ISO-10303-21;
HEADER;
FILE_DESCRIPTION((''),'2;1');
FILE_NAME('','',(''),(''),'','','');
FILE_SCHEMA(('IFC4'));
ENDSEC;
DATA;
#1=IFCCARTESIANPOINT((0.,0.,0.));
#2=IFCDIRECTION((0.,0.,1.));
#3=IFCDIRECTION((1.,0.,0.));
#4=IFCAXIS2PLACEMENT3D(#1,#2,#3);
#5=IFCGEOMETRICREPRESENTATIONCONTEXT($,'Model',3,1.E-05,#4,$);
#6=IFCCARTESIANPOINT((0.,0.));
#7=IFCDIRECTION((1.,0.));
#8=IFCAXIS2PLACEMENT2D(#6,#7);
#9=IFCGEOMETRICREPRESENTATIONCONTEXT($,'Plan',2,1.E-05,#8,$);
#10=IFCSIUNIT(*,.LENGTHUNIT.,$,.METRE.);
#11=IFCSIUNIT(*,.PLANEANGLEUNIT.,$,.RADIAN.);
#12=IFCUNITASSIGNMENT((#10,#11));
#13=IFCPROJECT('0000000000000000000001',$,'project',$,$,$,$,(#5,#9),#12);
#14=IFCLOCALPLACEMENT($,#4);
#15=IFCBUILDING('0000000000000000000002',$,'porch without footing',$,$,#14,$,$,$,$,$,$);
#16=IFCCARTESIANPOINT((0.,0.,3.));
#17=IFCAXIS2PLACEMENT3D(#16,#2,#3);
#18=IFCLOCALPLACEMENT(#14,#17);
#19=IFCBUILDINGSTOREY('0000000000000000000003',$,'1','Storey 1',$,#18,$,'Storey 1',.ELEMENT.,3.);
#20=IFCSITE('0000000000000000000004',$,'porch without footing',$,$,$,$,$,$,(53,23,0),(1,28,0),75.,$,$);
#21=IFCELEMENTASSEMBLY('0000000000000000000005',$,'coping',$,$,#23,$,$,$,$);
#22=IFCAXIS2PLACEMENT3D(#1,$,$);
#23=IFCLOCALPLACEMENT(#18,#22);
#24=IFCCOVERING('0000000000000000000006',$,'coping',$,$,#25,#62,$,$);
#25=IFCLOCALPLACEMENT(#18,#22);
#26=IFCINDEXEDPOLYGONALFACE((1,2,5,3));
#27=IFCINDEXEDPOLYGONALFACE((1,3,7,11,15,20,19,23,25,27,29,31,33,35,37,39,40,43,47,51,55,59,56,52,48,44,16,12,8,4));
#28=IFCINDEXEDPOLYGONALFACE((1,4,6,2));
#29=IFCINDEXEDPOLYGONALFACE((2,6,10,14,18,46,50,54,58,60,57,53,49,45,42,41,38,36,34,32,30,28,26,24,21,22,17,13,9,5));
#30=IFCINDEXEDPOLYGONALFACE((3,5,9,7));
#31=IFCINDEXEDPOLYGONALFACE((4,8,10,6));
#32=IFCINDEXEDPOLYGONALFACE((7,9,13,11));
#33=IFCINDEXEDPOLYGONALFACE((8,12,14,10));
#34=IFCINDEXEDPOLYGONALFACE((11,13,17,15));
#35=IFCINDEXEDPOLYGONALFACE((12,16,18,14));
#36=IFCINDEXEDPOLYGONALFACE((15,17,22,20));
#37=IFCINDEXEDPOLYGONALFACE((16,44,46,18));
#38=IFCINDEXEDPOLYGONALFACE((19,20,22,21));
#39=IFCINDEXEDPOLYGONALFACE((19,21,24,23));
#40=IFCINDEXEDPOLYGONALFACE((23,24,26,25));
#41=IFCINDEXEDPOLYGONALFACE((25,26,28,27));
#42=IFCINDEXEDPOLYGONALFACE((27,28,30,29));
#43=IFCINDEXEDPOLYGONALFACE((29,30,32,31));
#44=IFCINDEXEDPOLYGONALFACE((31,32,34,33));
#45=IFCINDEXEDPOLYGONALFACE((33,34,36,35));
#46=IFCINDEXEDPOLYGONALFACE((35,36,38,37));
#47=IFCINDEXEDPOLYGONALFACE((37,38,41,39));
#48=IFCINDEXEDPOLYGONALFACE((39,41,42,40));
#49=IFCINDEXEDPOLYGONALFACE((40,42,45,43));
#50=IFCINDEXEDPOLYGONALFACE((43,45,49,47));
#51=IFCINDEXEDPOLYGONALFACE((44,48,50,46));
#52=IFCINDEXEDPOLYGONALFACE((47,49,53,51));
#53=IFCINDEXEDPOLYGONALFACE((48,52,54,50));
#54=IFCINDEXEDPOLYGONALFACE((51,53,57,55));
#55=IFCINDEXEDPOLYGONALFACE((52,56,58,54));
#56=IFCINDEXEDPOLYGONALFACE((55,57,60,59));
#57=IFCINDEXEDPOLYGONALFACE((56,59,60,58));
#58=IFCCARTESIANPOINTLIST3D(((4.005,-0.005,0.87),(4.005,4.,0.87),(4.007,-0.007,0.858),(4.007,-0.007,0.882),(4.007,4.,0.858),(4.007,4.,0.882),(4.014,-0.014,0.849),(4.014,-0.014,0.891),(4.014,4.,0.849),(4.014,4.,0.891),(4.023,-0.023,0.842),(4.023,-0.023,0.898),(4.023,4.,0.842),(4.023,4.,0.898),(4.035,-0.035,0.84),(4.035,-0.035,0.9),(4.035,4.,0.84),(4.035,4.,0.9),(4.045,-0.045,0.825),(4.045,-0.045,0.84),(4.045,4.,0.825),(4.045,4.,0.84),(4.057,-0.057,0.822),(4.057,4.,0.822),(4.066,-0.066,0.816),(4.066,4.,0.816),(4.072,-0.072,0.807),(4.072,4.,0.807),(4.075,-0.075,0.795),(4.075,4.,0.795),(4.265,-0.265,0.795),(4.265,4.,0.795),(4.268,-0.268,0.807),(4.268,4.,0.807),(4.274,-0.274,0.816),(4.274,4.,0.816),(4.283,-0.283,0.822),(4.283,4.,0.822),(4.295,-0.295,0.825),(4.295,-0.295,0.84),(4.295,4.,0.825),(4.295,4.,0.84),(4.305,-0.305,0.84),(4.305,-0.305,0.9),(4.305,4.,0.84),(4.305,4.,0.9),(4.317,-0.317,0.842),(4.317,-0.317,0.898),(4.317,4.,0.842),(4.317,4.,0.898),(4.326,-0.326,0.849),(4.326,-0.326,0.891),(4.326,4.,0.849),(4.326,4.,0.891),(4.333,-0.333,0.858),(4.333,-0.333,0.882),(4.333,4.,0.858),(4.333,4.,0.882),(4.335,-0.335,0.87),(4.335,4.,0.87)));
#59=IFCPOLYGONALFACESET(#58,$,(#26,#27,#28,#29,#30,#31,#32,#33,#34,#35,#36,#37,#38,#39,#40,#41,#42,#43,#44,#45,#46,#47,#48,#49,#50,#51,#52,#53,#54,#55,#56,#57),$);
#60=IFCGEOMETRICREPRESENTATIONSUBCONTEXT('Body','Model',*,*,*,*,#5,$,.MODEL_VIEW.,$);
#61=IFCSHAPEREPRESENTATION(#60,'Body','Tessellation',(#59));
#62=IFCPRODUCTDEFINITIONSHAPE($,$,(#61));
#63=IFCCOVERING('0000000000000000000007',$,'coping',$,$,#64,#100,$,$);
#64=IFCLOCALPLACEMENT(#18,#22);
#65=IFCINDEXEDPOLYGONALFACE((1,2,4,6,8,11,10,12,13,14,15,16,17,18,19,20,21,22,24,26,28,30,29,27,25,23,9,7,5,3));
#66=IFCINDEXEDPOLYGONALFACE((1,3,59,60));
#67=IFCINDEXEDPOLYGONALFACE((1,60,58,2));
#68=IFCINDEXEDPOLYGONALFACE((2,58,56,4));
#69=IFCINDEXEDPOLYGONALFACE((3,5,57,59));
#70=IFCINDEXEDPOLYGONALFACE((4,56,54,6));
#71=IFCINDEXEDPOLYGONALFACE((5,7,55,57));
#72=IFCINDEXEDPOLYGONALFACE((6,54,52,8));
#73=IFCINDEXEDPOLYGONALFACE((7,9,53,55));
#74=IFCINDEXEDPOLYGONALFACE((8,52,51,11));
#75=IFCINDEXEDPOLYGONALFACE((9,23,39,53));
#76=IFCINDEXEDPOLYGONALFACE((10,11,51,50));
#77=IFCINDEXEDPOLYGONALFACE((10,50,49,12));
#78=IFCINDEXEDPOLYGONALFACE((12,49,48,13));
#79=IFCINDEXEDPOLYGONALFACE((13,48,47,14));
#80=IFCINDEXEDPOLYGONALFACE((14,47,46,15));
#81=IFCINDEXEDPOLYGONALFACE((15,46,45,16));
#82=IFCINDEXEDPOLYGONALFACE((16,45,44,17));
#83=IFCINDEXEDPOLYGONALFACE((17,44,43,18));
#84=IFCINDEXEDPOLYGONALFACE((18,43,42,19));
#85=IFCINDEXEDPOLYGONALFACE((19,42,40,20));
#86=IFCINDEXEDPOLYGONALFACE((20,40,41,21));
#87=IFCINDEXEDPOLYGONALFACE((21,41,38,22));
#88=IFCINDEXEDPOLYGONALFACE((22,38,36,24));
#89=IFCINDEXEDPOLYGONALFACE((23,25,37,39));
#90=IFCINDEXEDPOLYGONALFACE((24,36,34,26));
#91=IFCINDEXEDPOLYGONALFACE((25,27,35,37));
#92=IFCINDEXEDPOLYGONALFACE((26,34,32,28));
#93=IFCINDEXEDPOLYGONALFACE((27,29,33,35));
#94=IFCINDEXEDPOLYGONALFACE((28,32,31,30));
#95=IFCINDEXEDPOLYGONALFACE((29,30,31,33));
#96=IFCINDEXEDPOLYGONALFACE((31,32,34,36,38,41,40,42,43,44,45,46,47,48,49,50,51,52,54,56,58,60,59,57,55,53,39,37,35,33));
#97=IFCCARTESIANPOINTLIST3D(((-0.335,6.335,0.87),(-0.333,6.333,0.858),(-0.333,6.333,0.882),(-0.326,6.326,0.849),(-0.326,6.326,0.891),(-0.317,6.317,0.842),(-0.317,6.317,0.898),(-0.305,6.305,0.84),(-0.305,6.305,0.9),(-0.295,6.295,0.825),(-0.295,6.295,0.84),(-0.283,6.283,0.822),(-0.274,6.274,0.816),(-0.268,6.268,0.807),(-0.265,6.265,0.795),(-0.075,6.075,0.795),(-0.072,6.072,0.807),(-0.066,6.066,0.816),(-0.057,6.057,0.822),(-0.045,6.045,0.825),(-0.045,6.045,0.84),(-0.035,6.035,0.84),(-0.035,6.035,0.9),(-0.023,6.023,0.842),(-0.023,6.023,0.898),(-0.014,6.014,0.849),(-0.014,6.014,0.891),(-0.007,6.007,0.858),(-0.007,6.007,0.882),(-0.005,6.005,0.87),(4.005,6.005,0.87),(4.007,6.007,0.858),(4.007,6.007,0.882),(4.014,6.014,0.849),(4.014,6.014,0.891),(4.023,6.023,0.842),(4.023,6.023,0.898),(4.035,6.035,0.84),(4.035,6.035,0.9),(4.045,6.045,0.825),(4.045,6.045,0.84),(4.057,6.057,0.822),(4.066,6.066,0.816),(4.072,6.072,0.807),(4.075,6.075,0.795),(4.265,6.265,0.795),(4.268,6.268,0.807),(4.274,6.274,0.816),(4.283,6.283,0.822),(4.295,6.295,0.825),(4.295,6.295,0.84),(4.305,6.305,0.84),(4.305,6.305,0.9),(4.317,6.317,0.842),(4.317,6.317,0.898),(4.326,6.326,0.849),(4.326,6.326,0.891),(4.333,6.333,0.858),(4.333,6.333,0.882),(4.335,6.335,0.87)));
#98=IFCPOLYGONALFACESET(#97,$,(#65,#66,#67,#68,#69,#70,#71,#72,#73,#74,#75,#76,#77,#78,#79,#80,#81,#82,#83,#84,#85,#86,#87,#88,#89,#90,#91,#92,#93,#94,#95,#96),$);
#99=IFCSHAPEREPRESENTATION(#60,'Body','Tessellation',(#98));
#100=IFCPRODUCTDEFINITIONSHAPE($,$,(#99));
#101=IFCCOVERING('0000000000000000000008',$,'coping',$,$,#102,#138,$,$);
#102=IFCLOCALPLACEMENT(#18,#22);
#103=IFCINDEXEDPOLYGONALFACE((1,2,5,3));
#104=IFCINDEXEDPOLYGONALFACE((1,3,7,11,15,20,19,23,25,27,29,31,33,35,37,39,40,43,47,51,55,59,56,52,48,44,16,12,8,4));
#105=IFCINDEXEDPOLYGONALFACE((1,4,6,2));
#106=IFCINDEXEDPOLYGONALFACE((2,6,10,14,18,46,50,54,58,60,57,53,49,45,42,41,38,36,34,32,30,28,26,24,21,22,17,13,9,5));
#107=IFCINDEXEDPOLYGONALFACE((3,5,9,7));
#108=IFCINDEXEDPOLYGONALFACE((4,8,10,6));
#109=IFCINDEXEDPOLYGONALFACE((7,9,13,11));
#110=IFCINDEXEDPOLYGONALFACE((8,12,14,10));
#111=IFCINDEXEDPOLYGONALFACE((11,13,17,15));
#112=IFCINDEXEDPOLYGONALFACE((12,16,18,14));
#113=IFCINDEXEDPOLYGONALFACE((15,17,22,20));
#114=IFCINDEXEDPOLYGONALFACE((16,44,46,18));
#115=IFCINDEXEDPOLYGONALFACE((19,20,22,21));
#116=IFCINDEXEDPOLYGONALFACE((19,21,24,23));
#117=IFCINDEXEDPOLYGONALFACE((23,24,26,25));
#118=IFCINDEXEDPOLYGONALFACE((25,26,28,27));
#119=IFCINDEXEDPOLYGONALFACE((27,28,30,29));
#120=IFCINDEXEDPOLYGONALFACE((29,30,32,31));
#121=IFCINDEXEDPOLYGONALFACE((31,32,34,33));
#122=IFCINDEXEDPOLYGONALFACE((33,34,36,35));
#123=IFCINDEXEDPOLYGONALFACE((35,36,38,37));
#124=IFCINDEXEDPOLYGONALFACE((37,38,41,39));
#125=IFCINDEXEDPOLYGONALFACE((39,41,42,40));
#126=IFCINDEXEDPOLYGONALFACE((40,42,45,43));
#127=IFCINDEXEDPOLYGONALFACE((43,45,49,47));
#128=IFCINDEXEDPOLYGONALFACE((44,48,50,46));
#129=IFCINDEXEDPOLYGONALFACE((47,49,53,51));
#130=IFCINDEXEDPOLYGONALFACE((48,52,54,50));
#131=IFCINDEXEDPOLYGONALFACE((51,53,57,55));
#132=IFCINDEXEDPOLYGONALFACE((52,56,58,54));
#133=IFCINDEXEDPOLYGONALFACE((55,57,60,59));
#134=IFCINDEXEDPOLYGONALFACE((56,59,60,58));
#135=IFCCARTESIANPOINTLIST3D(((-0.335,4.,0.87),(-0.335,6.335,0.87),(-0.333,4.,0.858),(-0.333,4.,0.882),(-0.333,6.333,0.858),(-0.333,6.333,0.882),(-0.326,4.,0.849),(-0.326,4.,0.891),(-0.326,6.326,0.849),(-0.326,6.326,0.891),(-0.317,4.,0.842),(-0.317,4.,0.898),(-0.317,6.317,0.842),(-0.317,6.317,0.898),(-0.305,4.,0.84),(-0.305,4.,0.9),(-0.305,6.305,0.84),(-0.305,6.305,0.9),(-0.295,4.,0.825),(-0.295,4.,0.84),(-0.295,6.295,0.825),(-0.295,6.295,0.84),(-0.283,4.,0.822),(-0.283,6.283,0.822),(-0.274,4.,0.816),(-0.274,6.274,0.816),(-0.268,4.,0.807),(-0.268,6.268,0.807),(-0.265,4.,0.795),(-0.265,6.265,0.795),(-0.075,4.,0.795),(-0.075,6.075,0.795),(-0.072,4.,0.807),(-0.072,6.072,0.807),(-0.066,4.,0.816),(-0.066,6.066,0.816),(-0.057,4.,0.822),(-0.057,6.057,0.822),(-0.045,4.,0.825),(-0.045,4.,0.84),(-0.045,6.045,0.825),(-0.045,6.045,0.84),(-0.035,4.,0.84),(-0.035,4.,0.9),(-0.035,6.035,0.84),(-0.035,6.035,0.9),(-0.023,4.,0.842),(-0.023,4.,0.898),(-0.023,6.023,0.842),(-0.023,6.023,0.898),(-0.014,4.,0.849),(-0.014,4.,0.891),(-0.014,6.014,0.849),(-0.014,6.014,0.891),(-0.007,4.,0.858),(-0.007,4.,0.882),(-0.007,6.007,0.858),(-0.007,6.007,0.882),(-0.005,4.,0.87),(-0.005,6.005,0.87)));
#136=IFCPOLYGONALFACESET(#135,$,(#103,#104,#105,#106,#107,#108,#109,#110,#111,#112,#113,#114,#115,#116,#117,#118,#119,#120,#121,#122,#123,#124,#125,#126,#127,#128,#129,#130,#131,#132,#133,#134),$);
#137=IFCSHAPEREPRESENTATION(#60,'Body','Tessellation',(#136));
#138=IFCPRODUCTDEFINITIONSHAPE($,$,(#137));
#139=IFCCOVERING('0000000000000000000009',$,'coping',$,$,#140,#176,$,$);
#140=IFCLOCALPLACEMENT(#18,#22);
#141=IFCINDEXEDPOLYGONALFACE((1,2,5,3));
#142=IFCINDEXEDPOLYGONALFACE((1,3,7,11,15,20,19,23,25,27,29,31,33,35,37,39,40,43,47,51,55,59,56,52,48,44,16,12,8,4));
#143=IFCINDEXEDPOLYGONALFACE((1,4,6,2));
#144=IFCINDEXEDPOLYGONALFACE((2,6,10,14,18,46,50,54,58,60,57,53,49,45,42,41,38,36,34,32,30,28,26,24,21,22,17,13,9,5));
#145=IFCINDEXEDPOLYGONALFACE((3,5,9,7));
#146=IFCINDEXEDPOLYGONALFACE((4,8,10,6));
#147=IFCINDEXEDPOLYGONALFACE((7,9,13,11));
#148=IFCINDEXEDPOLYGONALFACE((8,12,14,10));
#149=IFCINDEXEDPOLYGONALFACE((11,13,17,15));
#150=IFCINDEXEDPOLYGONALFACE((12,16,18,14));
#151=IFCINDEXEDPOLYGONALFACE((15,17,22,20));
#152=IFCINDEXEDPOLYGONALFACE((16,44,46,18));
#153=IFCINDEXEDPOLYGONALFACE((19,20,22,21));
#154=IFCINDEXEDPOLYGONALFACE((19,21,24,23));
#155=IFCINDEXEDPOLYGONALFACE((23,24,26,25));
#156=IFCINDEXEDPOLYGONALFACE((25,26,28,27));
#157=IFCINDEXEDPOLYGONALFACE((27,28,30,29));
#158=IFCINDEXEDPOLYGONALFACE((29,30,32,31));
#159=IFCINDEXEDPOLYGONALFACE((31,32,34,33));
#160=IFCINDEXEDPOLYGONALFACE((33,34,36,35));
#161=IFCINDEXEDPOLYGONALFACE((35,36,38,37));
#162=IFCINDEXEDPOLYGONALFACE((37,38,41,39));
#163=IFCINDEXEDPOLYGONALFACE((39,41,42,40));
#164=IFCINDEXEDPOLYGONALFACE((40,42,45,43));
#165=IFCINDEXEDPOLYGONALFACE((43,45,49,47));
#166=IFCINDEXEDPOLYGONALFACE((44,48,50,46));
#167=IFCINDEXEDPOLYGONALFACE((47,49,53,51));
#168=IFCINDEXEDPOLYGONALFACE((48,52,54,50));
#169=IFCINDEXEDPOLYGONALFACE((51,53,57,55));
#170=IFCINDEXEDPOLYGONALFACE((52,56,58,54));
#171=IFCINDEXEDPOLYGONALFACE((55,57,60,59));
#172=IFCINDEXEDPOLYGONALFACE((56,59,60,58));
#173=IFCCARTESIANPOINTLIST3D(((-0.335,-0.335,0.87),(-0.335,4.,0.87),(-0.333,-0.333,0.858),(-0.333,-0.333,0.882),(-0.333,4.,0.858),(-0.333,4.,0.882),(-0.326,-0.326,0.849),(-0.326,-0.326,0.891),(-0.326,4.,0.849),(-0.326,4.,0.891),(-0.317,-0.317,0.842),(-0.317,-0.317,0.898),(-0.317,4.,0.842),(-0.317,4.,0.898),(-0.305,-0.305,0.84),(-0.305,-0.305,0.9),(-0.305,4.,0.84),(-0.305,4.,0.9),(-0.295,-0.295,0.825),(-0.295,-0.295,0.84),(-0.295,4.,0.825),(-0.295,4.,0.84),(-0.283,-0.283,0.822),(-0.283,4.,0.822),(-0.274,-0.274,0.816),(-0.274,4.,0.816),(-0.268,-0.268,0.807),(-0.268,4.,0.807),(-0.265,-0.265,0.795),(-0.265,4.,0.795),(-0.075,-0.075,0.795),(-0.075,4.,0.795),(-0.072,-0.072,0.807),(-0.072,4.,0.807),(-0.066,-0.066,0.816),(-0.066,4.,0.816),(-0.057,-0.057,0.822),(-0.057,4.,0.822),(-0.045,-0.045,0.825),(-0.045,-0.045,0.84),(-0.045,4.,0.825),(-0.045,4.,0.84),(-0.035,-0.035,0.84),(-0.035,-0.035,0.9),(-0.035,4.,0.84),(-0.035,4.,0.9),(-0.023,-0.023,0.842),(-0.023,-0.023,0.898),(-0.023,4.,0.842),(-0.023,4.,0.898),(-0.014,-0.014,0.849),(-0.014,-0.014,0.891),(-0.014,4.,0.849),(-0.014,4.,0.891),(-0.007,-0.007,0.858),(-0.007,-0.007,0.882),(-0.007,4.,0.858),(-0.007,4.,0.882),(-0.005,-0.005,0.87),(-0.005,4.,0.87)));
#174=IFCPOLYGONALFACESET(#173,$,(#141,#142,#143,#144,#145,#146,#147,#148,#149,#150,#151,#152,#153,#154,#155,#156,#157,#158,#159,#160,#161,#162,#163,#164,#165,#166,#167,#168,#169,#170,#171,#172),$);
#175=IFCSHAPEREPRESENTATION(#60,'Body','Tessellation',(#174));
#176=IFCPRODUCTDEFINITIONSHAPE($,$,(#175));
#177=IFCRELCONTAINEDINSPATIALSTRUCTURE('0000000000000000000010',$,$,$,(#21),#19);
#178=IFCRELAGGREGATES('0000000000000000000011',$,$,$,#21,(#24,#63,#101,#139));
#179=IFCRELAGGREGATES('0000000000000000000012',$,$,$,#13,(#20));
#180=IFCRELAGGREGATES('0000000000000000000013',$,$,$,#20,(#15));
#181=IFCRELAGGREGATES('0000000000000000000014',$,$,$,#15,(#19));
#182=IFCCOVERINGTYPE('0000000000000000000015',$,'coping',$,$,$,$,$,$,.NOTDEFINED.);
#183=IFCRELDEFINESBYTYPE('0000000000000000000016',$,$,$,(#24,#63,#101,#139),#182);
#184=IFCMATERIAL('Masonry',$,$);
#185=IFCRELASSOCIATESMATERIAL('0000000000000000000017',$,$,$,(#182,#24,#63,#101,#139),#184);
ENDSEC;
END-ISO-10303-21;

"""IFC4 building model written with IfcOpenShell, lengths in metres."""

from ifc_helpers import new_model, si_unit, frame, origin_with_axes, origin_2d_with_axis, place, context, subcontext, project, spatial, polyline, outline, extrude, clip, halfspace, material, material_profile, profile_set, profile_usage, type_object, element, aggregate, save


model = new_model("IFC4")

# Units and contexts
model_context = context("Model", 3, precision=1e-05, world=origin_with_axes())
plan_context = context("Plan", 2, precision=1e-05, world=origin_2d_with_axis())
body_context = subcontext(model_context, "Body", "Model", "MODEL_VIEW")
ifc_project = project(units=[si_unit("LENGTHUNIT", "METRE"), si_unit("PLANEANGLEUNIT", "RADIAN")], contexts=[model_context, plan_context])

# Site, building, storey
site = spatial("IfcSite", under=ifc_project, Name="porch without footing", RefLatitude=(53, 23, 0), RefLongitude=(1, 28, 0), RefElevation=75.0)
building_placement = place(None, origin_with_axes())
building = spatial("IfcBuilding", under=site, at=building_placement, Name="porch without footing")
storey_placement = place(building_placement, frame((0.0, 0.0, 3.0), z_axis=(0.0, 0.0, 1.0), x_axis=(1.0, 0.0, 0.0)))
storey = spatial("IfcBuildingStorey", under=building, at=storey_placement, Name="1", Description="Storey 1", LongName="Storey 1", CompositionType="ELEMENT", Elevation=3.0)

# Shared definitions
ifc_material_1 = material(Name="Masonry")

# Element assembly, coverings
assembly_1_placement = place(storey_placement, frame((0.0, 0.0, -3.0), z_axis=(0.0, 0.0, 1.0), x_axis=(1.0, 0.0, 0.0)))
assembly_1 = element("IfcElementAssembly", 1, at=assembly_1_placement, inside=storey, Name="coping")
ifc_material_profile_1 = material_profile(ifc_material_1, outline(polyline([(0.265, 0.795), (0.268, 0.807), (0.274, 0.816), (0.283, 0.822), (0.295, 0.825), (0.295, 0.84), (0.305, 0.84), (0.317, 0.842), (0.326, 0.849), (0.333, 0.858), (0.335, 0.87), (0.333, 0.882), (0.326, 0.891), (0.317, 0.898), (0.305, 0.9), (0.035, 0.9), (0.023, 0.898), (0.014, 0.891), (0.007, 0.882), (0.005, 0.87), (0.007, 0.858), (0.014, 0.849), (0.023, 0.842), (0.035, 0.84), (0.045, 0.84), (0.045, 0.825), (0.057, 0.822), (0.066, 0.816), (0.072, 0.807), (0.075, 0.795), (0.265, 0.795)])))
ifc_profile_set_1 = profile_set([ifc_material_profile_1])
covering_type_1 = type_object("IfcCoveringType", Name="coping", PredefinedType="NOTDEFINED", material=ifc_profile_set_1)
ifc_profile_usage_1 = profile_usage(ifc_profile_set_1)
covering_1_placement = place(assembly_1_placement, frame((4.0, 5.0, 3.0), z_axis=(0.0, -1.0, 0.0), x_axis=(1.0, 0.0, 0.0)))
covering_1 = element("IfcCovering", 2, at=covering_1_placement, type_object=covering_type_1, material=ifc_profile_usage_1, Name="coping", context=body_context, shape_type="Clipping", body=[
    clip(clip(extrude(outline(polyline([(0.265, 0.795), (0.268, 0.807), (0.274, 0.816), (0.283, 0.822), (0.295, 0.825), (0.295, 0.84), (0.305, 0.84), (0.317, 0.842), (0.326, 0.849), (0.333, 0.858), (0.335, 0.87), (0.333, 0.882), (0.326, 0.891), (0.317, 0.898), (0.305, 0.9), (0.035, 0.9), (0.023, 0.898), (0.014, 0.891), (0.007, 0.882), (0.005, 0.87), (0.007, 0.858), (0.014, 0.849), (0.023, 0.842), (0.035, 0.84), (0.045, 0.84), (0.045, 0.825), (0.057, 0.822), (0.066, 0.816), (0.072, 0.807), (0.075, 0.795), (0.265, 0.795)])), origin_with_axes(), (0.0, 0.0, 1.0), 6.0), halfspace(frame((0.0, -3.0, 1.0), z_axis=(0.0, 0.0, -1.0), x_axis=(1.0, 0.0, 0.0)), False)), halfspace(frame((0.0, -3.0, 5.0), z_axis=(-0.707107, 0.0, 0.707107), x_axis=(0.0, 1.0, 0.0)), False)),
])
ifc_profile_usage_2 = profile_usage(ifc_profile_set_1)
covering_2_placement = place(assembly_1_placement, frame((-1.0, 6.0, 3.0), z_axis=(1.0, 0.0, 0.0), x_axis=(0.0, 1.0, 0.0)))
covering_2 = element("IfcCovering", 3, at=covering_2_placement, type_object=covering_type_1, material=ifc_profile_usage_2, Name="coping", context=body_context, shape_type="Clipping", body=[
    clip(clip(extrude(outline(polyline([(0.265, 0.795), (0.268, 0.807), (0.274, 0.816), (0.283, 0.822), (0.295, 0.825), (0.295, 0.84), (0.305, 0.84), (0.317, 0.842), (0.326, 0.849), (0.333, 0.858), (0.335, 0.87), (0.333, 0.882), (0.326, 0.891), (0.317, 0.898), (0.305, 0.9), (0.035, 0.9), (0.023, 0.898), (0.014, 0.891), (0.007, 0.882), (0.005, 0.87), (0.007, 0.858), (0.014, 0.849), (0.023, 0.842), (0.035, 0.84), (0.045, 0.84), (0.045, 0.825), (0.057, 0.822), (0.066, 0.816), (0.072, 0.807), (0.075, 0.795), (0.265, 0.795)])), origin_with_axes(), (0.0, 0.0, 1.0), 6.0), halfspace(frame((0.0, -3.0, 1.0), z_axis=(-0.707107, 0.0, -0.707107), x_axis=(0.0, 1.0, 0.0)), False)), halfspace(frame((0.0, -3.0, 5.0), z_axis=(-0.707107, 0.0, 0.707107), x_axis=(0.0, 1.0, 0.0)), False)),
])
ifc_profile_usage_3 = profile_usage(ifc_profile_set_1)
covering_3_placement = place(assembly_1_placement, frame((0.0, 3.0, 3.0), z_axis=(0.0, 1.0, 0.0), x_axis=(-1.0, 0.0, 0.0)))
covering_3 = element("IfcCovering", 4, at=covering_3_placement, type_object=covering_type_1, material=ifc_profile_usage_3, Name="coping", context=body_context, shape_type="Clipping", body=[
    clip(clip(extrude(outline(polyline([(0.265, 0.795), (0.268, 0.807), (0.274, 0.816), (0.283, 0.822), (0.295, 0.825), (0.295, 0.84), (0.305, 0.84), (0.317, 0.842), (0.326, 0.849), (0.333, 0.858), (0.335, 0.87), (0.333, 0.882), (0.326, 0.891), (0.317, 0.898), (0.305, 0.9), (0.035, 0.9), (0.023, 0.898), (0.014, 0.891), (0.007, 0.882), (0.005, 0.87), (0.007, 0.858), (0.014, 0.849), (0.023, 0.842), (0.035, 0.84), (0.045, 0.84), (0.045, 0.825), (0.057, 0.822), (0.066, 0.816), (0.072, 0.807), (0.075, 0.795), (0.265, 0.795)])), origin_with_axes(), (0.0, 0.0, 1.0), 4.0), halfspace(frame((0.0, -3.0, 1.0), z_axis=(0.0, 0.0, -1.0), x_axis=(1.0, 0.0, 0.0)), False)), halfspace(frame((0.0, -3.0, 3.0), z_axis=(-0.707107, 0.0, 0.707107), x_axis=(0.0, 1.0, 0.0)), False)),
])
ifc_profile_usage_4 = profile_usage(ifc_profile_set_1)
covering_4_placement = place(assembly_1_placement, frame((0.0, -1.0, 3.0), z_axis=(0.0, 1.0, 0.0), x_axis=(-1.0, 0.0, 0.0)))
covering_4 = element("IfcCovering", 5, at=covering_4_placement, type_object=covering_type_1, material=ifc_profile_usage_4, Name="coping", context=body_context, shape_type="Clipping", body=[
    clip(clip(extrude(outline(polyline([(0.265, 0.795), (0.268, 0.807), (0.274, 0.816), (0.283, 0.822), (0.295, 0.825), (0.295, 0.84), (0.305, 0.84), (0.317, 0.842), (0.326, 0.849), (0.333, 0.858), (0.335, 0.87), (0.333, 0.882), (0.326, 0.891), (0.317, 0.898), (0.305, 0.9), (0.035, 0.9), (0.023, 0.898), (0.014, 0.891), (0.007, 0.882), (0.005, 0.87), (0.007, 0.858), (0.014, 0.849), (0.023, 0.842), (0.035, 0.84), (0.045, 0.84), (0.045, 0.825), (0.057, 0.822), (0.066, 0.816), (0.072, 0.807), (0.075, 0.795), (0.265, 0.795)])), origin_with_axes(), (0.0, 0.0, 1.0), 6.0), halfspace(frame((0.0, -3.0, 1.0), z_axis=(-0.707107, 0.0, -0.707107), x_axis=(0.0, 1.0, 0.0)), False)), halfspace(frame((0.0, -3.0, 5.0), z_axis=(0.0, 0.0, 1.0), x_axis=(-1.0, 0.0, 0.0)), False)),
])
aggregate(assembly_1, [covering_1, covering_2, covering_3, covering_4])

save(model, "model.ifc")
